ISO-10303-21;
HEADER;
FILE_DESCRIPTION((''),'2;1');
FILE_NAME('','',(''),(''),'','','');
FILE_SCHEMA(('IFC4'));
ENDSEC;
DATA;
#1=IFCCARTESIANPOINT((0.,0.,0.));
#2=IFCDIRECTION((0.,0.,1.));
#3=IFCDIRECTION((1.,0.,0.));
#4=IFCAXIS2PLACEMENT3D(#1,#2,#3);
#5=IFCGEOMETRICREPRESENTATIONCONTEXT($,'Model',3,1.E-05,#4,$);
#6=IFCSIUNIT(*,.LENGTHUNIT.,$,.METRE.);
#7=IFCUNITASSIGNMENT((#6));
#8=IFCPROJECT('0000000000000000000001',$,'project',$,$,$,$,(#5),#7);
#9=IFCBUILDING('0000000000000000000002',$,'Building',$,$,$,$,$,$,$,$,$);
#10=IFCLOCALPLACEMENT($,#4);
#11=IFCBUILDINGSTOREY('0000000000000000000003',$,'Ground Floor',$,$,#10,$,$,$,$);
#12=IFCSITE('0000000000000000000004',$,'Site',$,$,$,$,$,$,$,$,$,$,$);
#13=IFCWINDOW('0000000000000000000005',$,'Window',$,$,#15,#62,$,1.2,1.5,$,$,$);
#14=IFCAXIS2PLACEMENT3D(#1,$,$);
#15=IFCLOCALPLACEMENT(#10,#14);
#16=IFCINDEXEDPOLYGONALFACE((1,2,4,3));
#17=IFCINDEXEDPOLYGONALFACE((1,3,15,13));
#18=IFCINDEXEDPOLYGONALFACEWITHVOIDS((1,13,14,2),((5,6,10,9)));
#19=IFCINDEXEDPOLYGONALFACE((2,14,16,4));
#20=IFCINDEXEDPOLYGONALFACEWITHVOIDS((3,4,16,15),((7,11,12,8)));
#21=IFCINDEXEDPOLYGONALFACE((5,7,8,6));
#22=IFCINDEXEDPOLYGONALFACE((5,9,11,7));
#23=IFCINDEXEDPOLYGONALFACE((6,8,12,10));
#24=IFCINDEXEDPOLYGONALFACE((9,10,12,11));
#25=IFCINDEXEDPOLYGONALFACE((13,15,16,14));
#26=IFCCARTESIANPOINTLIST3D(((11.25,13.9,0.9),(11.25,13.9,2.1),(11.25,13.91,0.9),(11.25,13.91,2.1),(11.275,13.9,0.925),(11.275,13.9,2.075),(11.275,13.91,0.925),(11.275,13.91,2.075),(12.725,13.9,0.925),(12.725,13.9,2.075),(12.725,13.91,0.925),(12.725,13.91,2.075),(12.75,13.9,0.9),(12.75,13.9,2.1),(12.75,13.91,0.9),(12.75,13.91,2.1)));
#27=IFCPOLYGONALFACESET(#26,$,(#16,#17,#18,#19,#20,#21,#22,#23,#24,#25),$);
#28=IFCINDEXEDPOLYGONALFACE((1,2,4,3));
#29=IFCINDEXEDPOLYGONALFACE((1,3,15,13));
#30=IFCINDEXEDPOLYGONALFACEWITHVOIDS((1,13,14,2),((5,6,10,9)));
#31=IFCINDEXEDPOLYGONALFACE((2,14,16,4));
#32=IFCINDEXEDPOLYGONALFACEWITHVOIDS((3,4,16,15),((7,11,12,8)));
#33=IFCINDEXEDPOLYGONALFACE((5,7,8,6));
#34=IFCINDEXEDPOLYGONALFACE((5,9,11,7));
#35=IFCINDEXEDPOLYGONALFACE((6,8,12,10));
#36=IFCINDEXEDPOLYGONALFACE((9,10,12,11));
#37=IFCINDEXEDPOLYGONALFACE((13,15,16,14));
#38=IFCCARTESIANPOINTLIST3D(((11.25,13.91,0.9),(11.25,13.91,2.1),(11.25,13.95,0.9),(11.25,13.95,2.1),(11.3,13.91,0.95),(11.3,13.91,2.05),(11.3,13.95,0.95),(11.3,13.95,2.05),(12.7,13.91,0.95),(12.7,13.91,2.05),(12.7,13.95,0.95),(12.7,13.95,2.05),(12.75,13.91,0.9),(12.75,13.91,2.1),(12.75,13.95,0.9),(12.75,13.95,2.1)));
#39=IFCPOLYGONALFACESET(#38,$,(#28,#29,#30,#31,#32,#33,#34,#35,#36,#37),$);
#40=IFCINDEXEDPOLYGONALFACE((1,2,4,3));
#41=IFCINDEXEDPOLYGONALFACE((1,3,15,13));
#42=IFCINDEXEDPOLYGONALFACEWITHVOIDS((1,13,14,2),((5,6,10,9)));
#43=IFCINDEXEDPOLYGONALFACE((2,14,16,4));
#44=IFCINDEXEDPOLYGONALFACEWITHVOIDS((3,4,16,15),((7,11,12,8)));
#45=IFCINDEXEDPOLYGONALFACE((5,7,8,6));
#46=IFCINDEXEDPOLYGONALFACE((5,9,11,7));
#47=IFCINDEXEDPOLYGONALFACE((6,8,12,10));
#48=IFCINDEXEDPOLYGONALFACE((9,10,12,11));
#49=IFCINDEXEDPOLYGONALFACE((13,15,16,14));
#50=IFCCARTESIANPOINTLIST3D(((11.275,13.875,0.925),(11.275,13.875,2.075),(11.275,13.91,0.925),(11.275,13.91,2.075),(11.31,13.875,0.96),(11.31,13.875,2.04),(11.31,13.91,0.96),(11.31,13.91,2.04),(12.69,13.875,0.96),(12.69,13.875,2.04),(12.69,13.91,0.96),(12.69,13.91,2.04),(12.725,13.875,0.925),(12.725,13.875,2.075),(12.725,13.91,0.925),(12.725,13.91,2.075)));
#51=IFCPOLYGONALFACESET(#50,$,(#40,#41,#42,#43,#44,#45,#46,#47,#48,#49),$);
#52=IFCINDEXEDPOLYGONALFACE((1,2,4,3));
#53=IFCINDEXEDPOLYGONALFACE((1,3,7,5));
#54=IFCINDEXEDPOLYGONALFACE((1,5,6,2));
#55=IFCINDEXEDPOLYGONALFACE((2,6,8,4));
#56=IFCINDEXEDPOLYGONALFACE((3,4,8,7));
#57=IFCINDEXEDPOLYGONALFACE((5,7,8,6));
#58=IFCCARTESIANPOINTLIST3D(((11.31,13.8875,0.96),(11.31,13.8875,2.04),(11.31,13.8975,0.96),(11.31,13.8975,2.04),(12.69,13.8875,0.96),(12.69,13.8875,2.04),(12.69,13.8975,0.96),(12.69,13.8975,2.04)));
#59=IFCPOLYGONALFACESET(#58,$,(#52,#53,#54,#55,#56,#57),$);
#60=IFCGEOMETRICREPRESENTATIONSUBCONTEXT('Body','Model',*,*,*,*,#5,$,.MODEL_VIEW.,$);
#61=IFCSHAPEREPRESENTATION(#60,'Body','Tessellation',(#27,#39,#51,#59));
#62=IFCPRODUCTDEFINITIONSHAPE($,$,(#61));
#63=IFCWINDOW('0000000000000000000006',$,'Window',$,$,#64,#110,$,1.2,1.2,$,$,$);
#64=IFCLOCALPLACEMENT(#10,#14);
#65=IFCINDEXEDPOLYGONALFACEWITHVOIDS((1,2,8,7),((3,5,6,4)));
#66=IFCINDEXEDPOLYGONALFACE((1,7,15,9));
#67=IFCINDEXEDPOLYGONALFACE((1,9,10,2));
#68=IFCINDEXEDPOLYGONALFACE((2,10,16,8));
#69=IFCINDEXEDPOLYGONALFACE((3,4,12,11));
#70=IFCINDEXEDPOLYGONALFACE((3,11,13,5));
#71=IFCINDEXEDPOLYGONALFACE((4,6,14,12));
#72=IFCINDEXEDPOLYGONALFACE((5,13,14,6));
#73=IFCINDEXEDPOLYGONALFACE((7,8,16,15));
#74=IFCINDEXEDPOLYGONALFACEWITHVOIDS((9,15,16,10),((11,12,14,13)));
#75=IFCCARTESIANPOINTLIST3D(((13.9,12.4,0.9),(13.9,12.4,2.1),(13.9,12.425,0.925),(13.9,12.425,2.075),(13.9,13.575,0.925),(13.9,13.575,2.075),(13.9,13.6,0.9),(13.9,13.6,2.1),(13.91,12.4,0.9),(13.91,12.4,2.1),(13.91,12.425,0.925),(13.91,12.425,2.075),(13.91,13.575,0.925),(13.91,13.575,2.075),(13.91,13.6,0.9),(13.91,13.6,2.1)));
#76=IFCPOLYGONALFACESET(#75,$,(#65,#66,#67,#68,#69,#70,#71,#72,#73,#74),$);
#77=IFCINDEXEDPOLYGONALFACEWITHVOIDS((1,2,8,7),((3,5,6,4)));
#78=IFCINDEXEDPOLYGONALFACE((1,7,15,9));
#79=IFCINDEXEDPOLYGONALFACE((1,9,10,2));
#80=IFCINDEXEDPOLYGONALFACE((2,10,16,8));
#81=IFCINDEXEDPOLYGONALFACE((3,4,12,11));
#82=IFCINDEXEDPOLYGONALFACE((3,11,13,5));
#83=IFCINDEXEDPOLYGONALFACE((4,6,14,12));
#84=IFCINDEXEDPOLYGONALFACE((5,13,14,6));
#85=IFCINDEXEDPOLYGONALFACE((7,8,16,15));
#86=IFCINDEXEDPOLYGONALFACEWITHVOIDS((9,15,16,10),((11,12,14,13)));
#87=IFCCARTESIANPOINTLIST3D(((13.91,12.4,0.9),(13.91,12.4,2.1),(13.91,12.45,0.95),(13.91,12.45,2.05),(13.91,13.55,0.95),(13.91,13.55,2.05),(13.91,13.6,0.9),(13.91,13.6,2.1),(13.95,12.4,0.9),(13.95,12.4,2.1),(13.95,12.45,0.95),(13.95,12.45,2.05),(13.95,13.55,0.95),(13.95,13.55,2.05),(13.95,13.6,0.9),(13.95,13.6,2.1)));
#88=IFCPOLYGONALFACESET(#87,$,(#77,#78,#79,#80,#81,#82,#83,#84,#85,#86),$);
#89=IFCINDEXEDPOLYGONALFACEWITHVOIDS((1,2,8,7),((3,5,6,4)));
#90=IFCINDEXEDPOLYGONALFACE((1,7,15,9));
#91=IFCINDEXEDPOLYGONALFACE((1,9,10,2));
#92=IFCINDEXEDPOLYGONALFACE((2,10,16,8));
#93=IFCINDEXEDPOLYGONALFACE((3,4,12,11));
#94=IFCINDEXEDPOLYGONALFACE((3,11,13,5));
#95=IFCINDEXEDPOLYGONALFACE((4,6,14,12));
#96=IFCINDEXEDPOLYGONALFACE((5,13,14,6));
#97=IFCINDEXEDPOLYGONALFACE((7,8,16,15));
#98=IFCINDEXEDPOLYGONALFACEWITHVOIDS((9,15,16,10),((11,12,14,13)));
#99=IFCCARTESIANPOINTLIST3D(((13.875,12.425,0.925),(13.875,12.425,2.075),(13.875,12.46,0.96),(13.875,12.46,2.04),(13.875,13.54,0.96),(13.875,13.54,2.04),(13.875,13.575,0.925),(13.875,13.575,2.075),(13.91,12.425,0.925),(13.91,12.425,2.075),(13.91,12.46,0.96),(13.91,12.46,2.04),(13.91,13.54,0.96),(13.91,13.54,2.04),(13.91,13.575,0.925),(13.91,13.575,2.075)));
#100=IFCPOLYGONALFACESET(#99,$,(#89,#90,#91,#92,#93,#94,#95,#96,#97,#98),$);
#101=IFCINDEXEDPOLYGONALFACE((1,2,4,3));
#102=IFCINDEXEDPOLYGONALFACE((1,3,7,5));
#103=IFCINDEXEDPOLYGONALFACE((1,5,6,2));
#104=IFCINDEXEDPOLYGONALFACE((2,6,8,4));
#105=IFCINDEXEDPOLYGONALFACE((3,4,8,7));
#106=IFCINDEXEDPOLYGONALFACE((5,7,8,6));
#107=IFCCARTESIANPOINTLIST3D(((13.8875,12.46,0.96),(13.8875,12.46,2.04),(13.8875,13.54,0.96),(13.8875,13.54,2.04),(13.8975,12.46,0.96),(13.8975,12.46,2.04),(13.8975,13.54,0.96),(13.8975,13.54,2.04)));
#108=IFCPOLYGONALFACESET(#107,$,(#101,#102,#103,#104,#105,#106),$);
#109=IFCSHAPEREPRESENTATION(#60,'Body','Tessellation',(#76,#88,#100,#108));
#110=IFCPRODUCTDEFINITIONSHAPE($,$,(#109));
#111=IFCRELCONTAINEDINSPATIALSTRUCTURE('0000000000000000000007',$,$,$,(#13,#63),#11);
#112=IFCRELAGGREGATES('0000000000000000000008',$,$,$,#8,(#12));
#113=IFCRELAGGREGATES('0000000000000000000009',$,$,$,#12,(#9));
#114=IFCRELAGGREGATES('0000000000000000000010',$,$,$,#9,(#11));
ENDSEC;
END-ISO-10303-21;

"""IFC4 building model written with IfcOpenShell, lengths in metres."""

from ifc_helpers import new_model, si_unit, frame, origin_with_axes, place, context, subcontext, project, spatial, line, indexed_curve, outline, extrude, element, save


model = new_model("IFC4")

# Units and contexts
model_context = context("Model", 3, precision=1e-05, world=origin_with_axes())
body_context = subcontext(model_context, "Body", "Model", "MODEL_VIEW")
ifc_project = project(units=[si_unit("LENGTHUNIT", "METRE")], contexts=[model_context])

# Site, building, storey
site = spatial("IfcSite", under=ifc_project, Name="Site")
building = spatial("IfcBuilding", under=site, Name="Building")
storey_placement = place(None, origin_with_axes())
storey = spatial("IfcBuildingStorey", under=building, at=storey_placement, Name="Ground Floor")

# Windows
for number, where, z_axis, x_axis, name in (
    (1, (12.75, 14.0, 0.9), (0.0, 0.0, 1.0), (-1.0, 0.0, 0.0), "Window"),
):
    element("IfcWindow", number, at=place(storey_placement, frame(where, z_axis=z_axis, x_axis=x_axis)), inside=storey, Name=name, OverallHeight=1.2, OverallWidth=1.5, context=body_context, shape_type="SweptSolid", body=[
        extrude(outline(indexed_curve([(0.0, 0.0), (1.5, 0.0), (1.5, 1.2), (0.0, 1.2)], segments=[line(1, 2, 3, 4, 1)]), holes=[indexed_curve([(0.025, 0.025), (1.475, 0.025), (1.475, 1.175), (0.025, 1.175)], segments=[line(1, 2, 3, 4, 1)])]), frame((0.0, 0.09, 0.0), z_axis=(0.0, -1.0, 0.0), x_axis=(1.0, 0.0, 0.0)), (0.0, 0.0, -1.0), 0.01),
        extrude(outline(indexed_curve([(0.0, 0.0), (1.5, 0.0), (1.5, 1.2), (0.0, 1.2)], segments=[line(1, 2, 3, 4, 1)]), holes=[indexed_curve([(0.05, 0.05), (1.45, 0.05), (1.45, 1.15), (0.05, 1.15)], segments=[line(1, 2, 3, 4, 1)])]), frame((0.0, 0.05, 0.0), z_axis=(0.0, -1.0, 0.0), x_axis=(1.0, 0.0, 0.0)), (0.0, 0.0, -1.0), 0.04),
        extrude(outline(indexed_curve([(0.0, 0.0), (1.45, 0.0), (1.45, 1.15), (0.0, 1.15)], segments=[line(1, 2, 3, 4, 1)]), holes=[indexed_curve([(0.035, 0.035), (1.415, 0.035), (1.415, 1.115), (0.035, 1.115)], segments=[line(1, 2, 3, 4, 1)])]), frame((0.025, 0.09, 0.025), z_axis=(0.0, -1.0, 0.0), x_axis=(1.0, 0.0, 0.0)), (0.0, 0.0, -1.0), 0.035),
        extrude(outline(indexed_curve([(0.035, 0.035), (1.415, 0.035), (1.415, 1.115), (0.035, 1.115)], segments=[line(1, 2, 3, 4, 1)])), frame((0.025, 0.1025, 0.025), z_axis=(0.0, -1.0, 0.0), x_axis=(1.0, 0.0, 0.0)), (0.0, 0.0, -1.0), 0.01),
    ])
window_placement = place(storey_placement, frame((14.0, 12.4, 0.9), z_axis=(0.0, 0.0, 1.0), x_axis=(0.0, 1.0, 0.0)))
element("IfcWindow", 2, at=window_placement, inside=storey, Name="Window", OverallHeight=1.2, OverallWidth=1.2, context=body_context, shape_type="SweptSolid", body=[
    extrude(outline(indexed_curve([(0.0, 0.0), (1.2, 0.0), (1.2, 1.2), (0.0, 1.2)], segments=[line(1, 2, 3, 4, 1)]), holes=[indexed_curve([(0.025, 0.025), (1.175, 0.025), (1.175, 1.175), (0.025, 1.175)], segments=[line(1, 2, 3, 4, 1)])]), frame((0.0, 0.09, 0.0), z_axis=(0.0, -1.0, 0.0), x_axis=(1.0, 0.0, 0.0)), (0.0, 0.0, -1.0), 0.01),
    extrude(outline(indexed_curve([(0.0, 0.0), (1.2, 0.0), (1.2, 1.2), (0.0, 1.2)], segments=[line(1, 2, 3, 4, 1)]), holes=[indexed_curve([(0.05, 0.05), (1.15, 0.05), (1.15, 1.15), (0.05, 1.15)], segments=[line(1, 2, 3, 4, 1)])]), frame((0.0, 0.05, 0.0), z_axis=(0.0, -1.0, 0.0), x_axis=(1.0, 0.0, 0.0)), (0.0, 0.0, -1.0), 0.04),
    extrude(outline(indexed_curve([(0.0, 0.0), (1.15, 0.0), (1.15, 1.15), (0.0, 1.15)], segments=[line(1, 2, 3, 4, 1)]), holes=[indexed_curve([(0.035, 0.035), (1.115, 0.035), (1.115, 1.115), (0.035, 1.115)], segments=[line(1, 2, 3, 4, 1)])]), frame((0.025, 0.09, 0.025), z_axis=(0.0, -1.0, 0.0), x_axis=(1.0, 0.0, 0.0)), (0.0, 0.0, -1.0), 0.035),
    extrude(outline(indexed_curve([(0.035, 0.035), (1.115, 0.035), (1.115, 1.115), (0.035, 1.115)], segments=[line(1, 2, 3, 4, 1)])), frame((0.025, 0.1025, 0.025), z_axis=(0.0, -1.0, 0.0), x_axis=(1.0, 0.0, 0.0)), (0.0, 0.0, -1.0), 0.01),
])

save(model, "model.ifc")
